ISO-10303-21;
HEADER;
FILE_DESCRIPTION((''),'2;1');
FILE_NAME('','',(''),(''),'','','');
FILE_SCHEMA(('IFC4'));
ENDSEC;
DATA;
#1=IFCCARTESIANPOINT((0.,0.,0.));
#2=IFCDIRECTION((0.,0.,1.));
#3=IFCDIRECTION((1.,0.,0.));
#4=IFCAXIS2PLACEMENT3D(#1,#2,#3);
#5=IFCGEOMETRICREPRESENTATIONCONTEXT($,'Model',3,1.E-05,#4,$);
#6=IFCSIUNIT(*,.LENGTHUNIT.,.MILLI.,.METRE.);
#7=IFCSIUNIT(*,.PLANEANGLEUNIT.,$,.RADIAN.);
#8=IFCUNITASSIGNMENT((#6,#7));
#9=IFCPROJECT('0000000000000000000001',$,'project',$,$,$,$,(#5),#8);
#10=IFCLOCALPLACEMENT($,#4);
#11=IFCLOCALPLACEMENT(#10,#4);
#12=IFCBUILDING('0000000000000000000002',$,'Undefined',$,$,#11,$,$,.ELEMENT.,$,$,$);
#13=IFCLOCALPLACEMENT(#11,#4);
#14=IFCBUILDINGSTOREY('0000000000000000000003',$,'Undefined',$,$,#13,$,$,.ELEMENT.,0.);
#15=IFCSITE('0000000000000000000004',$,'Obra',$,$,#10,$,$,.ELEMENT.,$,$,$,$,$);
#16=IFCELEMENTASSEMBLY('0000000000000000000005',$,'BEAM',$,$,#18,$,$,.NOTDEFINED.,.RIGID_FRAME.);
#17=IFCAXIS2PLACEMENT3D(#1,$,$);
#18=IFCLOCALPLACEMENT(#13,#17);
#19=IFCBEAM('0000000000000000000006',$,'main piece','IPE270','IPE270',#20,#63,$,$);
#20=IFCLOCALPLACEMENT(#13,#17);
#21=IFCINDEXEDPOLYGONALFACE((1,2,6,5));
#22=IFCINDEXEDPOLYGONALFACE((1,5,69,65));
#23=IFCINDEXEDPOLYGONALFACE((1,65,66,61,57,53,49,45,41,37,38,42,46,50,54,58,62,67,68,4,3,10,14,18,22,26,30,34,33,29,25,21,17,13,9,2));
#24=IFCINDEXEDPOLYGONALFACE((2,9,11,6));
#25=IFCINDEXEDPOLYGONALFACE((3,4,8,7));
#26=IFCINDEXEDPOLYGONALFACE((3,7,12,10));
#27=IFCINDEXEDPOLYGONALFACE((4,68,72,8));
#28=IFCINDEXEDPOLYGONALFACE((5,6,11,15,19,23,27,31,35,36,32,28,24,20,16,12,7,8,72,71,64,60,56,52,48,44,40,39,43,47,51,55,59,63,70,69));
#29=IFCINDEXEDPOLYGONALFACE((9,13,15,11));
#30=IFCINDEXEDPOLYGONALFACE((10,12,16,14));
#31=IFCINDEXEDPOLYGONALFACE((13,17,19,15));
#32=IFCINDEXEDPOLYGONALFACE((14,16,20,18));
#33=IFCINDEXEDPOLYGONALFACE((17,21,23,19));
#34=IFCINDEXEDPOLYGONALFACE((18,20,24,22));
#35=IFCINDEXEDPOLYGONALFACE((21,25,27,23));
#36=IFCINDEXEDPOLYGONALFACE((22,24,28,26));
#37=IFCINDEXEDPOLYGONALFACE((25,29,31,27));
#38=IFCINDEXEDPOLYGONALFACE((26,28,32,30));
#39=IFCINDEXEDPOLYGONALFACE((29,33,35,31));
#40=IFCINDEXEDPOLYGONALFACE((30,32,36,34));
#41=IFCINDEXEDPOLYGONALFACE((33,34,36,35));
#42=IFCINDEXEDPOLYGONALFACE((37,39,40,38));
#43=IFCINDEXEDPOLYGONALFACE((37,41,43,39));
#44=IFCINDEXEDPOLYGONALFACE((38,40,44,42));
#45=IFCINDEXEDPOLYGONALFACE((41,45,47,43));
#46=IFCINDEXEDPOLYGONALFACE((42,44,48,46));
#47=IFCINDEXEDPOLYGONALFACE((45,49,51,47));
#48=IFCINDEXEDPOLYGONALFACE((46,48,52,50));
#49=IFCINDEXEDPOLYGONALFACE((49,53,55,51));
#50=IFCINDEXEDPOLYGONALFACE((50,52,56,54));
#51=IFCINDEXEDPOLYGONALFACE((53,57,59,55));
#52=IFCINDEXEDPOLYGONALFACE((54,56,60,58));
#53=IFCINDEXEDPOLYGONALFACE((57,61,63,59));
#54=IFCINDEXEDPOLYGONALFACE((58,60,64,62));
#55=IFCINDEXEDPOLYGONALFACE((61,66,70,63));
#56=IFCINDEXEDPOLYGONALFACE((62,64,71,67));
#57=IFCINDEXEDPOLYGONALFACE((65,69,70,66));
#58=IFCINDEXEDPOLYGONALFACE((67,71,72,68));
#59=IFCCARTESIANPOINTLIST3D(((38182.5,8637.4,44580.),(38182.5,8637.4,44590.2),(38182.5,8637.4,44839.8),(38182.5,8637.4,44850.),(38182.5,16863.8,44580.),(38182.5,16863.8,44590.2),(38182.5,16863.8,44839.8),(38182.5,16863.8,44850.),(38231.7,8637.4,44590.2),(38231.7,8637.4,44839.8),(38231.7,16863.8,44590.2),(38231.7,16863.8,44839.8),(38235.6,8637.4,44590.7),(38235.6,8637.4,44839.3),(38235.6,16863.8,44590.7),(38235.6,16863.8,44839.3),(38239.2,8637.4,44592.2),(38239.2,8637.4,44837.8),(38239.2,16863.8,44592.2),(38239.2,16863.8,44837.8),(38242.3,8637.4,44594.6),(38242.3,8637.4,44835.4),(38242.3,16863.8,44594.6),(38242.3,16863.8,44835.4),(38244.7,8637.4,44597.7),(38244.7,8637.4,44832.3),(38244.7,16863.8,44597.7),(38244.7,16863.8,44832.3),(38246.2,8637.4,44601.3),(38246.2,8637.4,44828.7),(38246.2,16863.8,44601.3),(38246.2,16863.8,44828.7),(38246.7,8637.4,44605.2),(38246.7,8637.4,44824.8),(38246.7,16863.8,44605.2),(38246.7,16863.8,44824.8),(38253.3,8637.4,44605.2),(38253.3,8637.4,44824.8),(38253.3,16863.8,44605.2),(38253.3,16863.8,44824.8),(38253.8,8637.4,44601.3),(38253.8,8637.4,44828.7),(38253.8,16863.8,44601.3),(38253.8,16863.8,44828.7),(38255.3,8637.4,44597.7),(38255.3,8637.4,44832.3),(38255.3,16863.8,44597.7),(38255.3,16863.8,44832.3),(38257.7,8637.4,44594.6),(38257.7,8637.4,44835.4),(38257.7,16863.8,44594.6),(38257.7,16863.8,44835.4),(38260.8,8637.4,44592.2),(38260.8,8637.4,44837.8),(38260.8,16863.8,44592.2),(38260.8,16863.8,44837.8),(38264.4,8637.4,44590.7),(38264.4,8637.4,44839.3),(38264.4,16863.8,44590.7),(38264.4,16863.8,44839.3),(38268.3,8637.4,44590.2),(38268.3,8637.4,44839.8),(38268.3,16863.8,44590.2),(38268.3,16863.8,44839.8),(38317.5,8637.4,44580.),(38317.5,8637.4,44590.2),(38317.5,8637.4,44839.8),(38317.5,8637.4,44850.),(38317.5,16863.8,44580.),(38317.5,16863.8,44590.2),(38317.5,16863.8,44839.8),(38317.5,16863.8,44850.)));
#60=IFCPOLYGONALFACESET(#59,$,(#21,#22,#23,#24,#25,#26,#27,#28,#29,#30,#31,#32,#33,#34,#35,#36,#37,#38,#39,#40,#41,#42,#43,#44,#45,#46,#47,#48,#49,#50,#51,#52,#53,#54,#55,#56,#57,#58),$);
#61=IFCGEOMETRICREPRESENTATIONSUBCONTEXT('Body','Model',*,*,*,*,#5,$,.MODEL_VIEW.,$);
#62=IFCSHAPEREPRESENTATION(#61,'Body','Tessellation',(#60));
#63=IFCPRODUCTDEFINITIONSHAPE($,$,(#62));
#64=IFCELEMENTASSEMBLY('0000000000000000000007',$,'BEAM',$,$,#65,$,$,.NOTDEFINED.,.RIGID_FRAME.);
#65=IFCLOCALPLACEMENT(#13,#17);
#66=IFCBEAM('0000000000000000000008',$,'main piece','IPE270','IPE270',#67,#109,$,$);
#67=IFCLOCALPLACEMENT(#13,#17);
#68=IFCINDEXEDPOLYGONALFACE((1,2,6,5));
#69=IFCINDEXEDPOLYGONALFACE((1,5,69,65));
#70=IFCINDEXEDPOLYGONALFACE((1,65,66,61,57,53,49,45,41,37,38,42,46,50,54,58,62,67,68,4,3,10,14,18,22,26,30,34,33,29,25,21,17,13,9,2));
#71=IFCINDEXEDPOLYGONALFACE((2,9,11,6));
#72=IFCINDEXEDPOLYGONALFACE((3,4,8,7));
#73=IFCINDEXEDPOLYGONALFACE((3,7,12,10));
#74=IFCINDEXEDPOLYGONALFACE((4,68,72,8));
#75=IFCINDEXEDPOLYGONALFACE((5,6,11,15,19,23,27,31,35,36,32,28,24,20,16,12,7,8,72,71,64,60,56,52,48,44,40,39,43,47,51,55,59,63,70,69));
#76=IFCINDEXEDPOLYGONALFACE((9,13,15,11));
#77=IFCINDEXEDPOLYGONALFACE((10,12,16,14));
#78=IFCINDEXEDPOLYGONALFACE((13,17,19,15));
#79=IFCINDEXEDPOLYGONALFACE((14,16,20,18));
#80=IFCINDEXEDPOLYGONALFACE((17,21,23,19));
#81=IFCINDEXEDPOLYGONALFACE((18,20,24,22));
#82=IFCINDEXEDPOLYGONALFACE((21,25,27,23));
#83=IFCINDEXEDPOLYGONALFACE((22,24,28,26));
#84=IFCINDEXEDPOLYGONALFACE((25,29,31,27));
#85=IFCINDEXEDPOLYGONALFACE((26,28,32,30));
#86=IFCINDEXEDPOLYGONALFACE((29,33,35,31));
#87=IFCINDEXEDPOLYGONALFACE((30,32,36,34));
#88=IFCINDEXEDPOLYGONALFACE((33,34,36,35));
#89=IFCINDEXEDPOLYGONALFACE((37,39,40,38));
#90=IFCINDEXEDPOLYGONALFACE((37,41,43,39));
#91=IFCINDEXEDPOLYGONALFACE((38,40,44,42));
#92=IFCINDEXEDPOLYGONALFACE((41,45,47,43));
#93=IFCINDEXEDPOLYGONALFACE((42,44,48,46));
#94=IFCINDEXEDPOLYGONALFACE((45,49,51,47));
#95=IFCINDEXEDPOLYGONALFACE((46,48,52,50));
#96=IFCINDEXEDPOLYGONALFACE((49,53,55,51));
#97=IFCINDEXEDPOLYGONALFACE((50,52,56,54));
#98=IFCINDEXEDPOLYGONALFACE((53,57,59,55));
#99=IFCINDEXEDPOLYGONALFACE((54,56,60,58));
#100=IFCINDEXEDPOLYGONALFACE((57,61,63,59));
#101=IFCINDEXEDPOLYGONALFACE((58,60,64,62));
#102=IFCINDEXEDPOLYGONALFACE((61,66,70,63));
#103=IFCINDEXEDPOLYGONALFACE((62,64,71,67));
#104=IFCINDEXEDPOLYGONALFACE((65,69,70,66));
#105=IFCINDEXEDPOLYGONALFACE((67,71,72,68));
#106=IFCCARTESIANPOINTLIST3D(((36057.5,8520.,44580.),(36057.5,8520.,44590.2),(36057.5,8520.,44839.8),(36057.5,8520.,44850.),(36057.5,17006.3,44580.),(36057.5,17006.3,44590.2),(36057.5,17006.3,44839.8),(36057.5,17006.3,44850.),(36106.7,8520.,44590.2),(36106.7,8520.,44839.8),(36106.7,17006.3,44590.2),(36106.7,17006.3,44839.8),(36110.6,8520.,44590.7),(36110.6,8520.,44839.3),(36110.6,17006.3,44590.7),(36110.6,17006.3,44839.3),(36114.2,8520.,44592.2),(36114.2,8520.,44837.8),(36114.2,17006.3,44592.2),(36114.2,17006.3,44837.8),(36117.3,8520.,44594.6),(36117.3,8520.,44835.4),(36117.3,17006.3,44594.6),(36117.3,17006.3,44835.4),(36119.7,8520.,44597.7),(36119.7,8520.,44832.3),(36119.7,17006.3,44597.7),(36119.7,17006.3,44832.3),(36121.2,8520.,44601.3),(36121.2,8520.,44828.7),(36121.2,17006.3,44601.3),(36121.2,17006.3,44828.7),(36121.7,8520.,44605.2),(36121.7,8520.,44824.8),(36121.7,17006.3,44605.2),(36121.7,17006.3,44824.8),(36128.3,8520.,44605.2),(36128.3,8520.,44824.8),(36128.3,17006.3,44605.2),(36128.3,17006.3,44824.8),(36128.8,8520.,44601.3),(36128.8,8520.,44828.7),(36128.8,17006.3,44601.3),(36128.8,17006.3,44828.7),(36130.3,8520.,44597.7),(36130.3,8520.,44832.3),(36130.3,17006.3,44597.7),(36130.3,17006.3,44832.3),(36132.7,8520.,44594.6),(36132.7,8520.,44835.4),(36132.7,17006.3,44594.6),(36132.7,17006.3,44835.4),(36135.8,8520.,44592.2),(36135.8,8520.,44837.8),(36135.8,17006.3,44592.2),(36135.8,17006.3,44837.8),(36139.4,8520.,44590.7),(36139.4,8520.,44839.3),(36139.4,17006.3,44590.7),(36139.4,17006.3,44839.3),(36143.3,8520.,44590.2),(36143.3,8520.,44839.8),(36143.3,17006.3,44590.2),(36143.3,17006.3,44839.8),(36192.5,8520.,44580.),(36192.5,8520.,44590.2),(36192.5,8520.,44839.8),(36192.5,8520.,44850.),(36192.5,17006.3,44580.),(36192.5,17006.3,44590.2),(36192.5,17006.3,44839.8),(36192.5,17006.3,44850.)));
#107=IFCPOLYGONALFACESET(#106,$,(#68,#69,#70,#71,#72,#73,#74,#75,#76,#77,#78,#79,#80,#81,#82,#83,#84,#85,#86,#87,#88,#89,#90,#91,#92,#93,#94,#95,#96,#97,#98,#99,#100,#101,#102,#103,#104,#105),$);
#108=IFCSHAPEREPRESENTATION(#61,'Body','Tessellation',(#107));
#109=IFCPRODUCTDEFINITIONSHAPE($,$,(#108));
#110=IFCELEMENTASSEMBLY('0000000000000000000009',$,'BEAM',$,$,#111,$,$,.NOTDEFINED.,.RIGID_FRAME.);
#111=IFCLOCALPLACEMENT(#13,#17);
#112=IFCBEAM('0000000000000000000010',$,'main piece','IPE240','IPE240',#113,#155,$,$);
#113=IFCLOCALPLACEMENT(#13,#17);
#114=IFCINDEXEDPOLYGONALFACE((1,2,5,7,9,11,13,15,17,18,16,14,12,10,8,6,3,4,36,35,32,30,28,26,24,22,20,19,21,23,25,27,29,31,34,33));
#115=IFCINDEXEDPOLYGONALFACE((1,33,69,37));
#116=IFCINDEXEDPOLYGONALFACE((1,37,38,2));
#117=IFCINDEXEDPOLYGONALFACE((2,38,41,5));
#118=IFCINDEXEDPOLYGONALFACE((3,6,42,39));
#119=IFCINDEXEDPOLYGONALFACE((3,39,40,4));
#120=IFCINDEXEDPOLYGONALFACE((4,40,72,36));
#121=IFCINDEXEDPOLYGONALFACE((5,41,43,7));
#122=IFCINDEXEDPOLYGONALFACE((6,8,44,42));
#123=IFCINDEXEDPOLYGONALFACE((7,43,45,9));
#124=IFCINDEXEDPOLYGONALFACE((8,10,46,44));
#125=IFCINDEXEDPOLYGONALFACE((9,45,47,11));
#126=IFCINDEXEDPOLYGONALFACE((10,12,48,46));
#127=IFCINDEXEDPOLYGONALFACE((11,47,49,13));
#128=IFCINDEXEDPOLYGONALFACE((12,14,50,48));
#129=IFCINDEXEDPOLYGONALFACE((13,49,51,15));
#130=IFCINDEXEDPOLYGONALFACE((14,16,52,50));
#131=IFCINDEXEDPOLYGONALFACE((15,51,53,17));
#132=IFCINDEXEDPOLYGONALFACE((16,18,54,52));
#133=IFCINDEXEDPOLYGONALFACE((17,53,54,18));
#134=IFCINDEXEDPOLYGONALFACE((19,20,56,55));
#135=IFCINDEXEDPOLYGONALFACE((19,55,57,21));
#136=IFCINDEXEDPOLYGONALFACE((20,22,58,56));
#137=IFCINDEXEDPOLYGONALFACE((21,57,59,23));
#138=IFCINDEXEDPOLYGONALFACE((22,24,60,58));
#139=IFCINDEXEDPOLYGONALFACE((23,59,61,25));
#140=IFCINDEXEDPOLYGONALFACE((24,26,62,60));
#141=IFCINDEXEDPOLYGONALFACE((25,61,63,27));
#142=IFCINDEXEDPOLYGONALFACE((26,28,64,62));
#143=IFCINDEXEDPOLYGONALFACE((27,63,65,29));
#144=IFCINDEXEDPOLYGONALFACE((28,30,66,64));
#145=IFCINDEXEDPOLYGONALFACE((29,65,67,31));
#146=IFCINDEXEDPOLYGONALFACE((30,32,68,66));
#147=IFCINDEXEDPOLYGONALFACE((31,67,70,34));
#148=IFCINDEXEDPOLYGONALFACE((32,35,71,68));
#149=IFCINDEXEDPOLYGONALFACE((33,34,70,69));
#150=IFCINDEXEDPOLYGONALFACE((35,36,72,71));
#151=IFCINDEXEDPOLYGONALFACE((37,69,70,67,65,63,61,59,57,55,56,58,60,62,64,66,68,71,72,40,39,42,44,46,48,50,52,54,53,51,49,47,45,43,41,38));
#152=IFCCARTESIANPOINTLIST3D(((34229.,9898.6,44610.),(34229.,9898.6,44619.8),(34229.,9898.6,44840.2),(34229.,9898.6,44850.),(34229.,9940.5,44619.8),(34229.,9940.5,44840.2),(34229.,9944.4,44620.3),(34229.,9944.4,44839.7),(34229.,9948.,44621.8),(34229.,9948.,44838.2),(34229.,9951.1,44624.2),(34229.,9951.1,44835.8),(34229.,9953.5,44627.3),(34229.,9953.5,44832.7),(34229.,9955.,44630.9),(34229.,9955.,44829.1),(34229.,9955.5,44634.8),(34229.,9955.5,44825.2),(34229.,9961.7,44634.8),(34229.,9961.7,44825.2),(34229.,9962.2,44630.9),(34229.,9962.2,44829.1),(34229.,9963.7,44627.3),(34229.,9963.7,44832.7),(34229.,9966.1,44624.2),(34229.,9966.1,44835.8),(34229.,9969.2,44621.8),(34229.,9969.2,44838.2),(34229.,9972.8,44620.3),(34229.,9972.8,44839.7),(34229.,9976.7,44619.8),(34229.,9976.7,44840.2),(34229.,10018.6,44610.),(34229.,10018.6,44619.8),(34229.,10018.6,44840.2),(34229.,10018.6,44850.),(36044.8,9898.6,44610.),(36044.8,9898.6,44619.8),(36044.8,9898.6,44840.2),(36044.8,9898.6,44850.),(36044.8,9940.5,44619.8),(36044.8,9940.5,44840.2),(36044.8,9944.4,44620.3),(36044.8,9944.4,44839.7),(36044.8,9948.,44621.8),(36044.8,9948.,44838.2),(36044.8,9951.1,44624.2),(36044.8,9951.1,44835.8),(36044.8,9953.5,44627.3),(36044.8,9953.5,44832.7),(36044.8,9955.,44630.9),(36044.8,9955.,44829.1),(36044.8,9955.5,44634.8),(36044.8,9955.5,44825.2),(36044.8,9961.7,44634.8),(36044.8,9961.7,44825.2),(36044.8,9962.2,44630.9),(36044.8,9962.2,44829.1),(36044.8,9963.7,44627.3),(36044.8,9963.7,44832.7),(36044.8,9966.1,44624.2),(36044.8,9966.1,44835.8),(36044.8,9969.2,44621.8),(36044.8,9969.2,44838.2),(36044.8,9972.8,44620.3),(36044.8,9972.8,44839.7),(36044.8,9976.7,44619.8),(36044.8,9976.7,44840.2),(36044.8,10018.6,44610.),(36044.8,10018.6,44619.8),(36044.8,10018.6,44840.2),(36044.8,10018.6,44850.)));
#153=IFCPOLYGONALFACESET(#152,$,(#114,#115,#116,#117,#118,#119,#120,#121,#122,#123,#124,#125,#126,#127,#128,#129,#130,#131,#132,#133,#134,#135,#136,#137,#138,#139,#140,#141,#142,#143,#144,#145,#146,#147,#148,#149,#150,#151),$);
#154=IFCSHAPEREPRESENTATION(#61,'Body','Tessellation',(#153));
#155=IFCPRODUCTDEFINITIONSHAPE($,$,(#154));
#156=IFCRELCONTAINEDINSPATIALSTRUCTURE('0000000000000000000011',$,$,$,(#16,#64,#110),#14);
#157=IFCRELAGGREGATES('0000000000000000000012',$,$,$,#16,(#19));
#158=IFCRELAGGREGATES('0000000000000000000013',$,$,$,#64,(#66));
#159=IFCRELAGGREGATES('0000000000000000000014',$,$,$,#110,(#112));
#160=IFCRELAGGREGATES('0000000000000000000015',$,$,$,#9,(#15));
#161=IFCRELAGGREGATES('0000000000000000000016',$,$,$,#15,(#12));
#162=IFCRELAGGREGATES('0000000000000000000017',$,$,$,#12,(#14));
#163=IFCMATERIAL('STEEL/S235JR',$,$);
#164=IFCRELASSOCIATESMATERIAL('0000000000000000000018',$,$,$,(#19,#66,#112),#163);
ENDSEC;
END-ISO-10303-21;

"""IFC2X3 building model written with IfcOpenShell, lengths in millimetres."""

from ifc_helpers import new_model, si_unit, frame, origin_with_axes, origin_2d_with_axis, place, context, subcontext, project, spatial, i_section, extrude, material, element, aggregate, save


model = new_model("IFC2X3")

# Units and contexts
model_context = context("Model", 3, precision=1e-05, world=origin_with_axes())
body_context = subcontext(model_context, "Body", "Model", "MODEL_VIEW")
ifc_project = project(units=[si_unit("LENGTHUNIT", "METRE", prefix="MILLI"), si_unit("PLANEANGLEUNIT", "RADIAN")], contexts=[model_context])

# Site, building, storey
site_placement = place(None, origin_with_axes())
site = spatial("IfcSite", under=ifc_project, at=site_placement, Name="Obra", CompositionType="ELEMENT")
building_placement = place(site_placement, origin_with_axes())
building = spatial("IfcBuilding", under=site, at=building_placement, Name="Undefined", CompositionType="ELEMENT")
storey_placement = place(building_placement, origin_with_axes())
storey = spatial("IfcBuildingStorey", under=building, at=storey_placement, Name="Undefined", CompositionType="ELEMENT", Elevation=0.0)

# Shared definitions
ifc_material_1 = material(Name="STEEL/S235JR")

# Element assemblies, beams
assembly_1_placement = place(storey_placement, origin_with_axes())
assembly_1 = element("IfcElementAssembly", 1, at=assembly_1_placement, inside=storey, Name="BEAM", AssemblyPlace="NOTDEFINED", PredefinedType="RIGID_FRAME")
beam_1_placement = place(assembly_1_placement, frame((38250.0, 8637.4, 44715.0), z_axis=(0.0, 0.0, 1.0), x_axis=(0.0, 1.0, 0.0)))
beam_1 = element("IfcBeam", 2, at=beam_1_placement, material=ifc_material_1, Name="main piece", Description="IPE270", ObjectType="IPE270", context=body_context, shape_type="SweptSolid", body=[
    extrude(i_section(OverallWidth=135.0, OverallDepth=270.0, WebThickness=6.6, FlangeThickness=10.2, FilletRadius=15.0, at=origin_2d_with_axis()), frame((8226.4, 0.0, 0.0), z_axis=(-1.0, 0.0, 0.0), x_axis=(0.0, -1.0, 0.0)), (0.0, 0.0, 1.0), 8226.4),
])
aggregate(assembly_1, [beam_1])
assembly_2_placement = place(storey_placement, origin_with_axes())
assembly_2 = element("IfcElementAssembly", 3, at=assembly_2_placement, inside=storey, Name="BEAM", AssemblyPlace="NOTDEFINED", PredefinedType="RIGID_FRAME")
beam_2_placement = place(assembly_2_placement, frame((36125.0, 8520.0, 44715.0), z_axis=(0.0, 0.0, 1.0), x_axis=(0.0, 1.0, 0.0)))
beam_2 = element("IfcBeam", 4, at=beam_2_placement, material=ifc_material_1, Name="main piece", Description="IPE270", ObjectType="IPE270", context=body_context, shape_type="SweptSolid", body=[
    extrude(i_section(OverallWidth=135.0, OverallDepth=270.0, WebThickness=6.6, FlangeThickness=10.2, FilletRadius=15.0, at=origin_2d_with_axis()), frame((8486.3, 0.0, 0.0), z_axis=(-1.0, 0.0, 0.0), x_axis=(0.0, -1.0, 0.0)), (0.0, 0.0, 1.0), 8486.3),
])
aggregate(assembly_2, [beam_2])
assembly_3_placement = place(storey_placement, origin_with_axes())
assembly_3 = element("IfcElementAssembly", 5, at=assembly_3_placement, inside=storey, Name="BEAM", AssemblyPlace="NOTDEFINED", PredefinedType="RIGID_FRAME")
beam_3_placement = place(assembly_3_placement, frame((34229.0, 9958.6, 44730.0), z_axis=(0.0, 0.0, 1.0), x_axis=(1.0, 0.0, 0.0)))
beam_3 = element("IfcBeam", 6, at=beam_3_placement, material=ifc_material_1, Name="main piece", Description="IPE240", ObjectType="IPE240", context=body_context, shape_type="SweptSolid", body=[
    extrude(i_section(OverallWidth=120.0, OverallDepth=240.0, WebThickness=6.2, FlangeThickness=9.8, FilletRadius=15.0, at=origin_2d_with_axis()), frame((1815.8, 0.0, 0.0), z_axis=(-1.0, 0.0, 0.0), x_axis=(0.0, -1.0, 0.0)), (0.0, 0.0, 1.0), 1815.8),
])
aggregate(assembly_3, [beam_3])

save(model, "model.ifc")
